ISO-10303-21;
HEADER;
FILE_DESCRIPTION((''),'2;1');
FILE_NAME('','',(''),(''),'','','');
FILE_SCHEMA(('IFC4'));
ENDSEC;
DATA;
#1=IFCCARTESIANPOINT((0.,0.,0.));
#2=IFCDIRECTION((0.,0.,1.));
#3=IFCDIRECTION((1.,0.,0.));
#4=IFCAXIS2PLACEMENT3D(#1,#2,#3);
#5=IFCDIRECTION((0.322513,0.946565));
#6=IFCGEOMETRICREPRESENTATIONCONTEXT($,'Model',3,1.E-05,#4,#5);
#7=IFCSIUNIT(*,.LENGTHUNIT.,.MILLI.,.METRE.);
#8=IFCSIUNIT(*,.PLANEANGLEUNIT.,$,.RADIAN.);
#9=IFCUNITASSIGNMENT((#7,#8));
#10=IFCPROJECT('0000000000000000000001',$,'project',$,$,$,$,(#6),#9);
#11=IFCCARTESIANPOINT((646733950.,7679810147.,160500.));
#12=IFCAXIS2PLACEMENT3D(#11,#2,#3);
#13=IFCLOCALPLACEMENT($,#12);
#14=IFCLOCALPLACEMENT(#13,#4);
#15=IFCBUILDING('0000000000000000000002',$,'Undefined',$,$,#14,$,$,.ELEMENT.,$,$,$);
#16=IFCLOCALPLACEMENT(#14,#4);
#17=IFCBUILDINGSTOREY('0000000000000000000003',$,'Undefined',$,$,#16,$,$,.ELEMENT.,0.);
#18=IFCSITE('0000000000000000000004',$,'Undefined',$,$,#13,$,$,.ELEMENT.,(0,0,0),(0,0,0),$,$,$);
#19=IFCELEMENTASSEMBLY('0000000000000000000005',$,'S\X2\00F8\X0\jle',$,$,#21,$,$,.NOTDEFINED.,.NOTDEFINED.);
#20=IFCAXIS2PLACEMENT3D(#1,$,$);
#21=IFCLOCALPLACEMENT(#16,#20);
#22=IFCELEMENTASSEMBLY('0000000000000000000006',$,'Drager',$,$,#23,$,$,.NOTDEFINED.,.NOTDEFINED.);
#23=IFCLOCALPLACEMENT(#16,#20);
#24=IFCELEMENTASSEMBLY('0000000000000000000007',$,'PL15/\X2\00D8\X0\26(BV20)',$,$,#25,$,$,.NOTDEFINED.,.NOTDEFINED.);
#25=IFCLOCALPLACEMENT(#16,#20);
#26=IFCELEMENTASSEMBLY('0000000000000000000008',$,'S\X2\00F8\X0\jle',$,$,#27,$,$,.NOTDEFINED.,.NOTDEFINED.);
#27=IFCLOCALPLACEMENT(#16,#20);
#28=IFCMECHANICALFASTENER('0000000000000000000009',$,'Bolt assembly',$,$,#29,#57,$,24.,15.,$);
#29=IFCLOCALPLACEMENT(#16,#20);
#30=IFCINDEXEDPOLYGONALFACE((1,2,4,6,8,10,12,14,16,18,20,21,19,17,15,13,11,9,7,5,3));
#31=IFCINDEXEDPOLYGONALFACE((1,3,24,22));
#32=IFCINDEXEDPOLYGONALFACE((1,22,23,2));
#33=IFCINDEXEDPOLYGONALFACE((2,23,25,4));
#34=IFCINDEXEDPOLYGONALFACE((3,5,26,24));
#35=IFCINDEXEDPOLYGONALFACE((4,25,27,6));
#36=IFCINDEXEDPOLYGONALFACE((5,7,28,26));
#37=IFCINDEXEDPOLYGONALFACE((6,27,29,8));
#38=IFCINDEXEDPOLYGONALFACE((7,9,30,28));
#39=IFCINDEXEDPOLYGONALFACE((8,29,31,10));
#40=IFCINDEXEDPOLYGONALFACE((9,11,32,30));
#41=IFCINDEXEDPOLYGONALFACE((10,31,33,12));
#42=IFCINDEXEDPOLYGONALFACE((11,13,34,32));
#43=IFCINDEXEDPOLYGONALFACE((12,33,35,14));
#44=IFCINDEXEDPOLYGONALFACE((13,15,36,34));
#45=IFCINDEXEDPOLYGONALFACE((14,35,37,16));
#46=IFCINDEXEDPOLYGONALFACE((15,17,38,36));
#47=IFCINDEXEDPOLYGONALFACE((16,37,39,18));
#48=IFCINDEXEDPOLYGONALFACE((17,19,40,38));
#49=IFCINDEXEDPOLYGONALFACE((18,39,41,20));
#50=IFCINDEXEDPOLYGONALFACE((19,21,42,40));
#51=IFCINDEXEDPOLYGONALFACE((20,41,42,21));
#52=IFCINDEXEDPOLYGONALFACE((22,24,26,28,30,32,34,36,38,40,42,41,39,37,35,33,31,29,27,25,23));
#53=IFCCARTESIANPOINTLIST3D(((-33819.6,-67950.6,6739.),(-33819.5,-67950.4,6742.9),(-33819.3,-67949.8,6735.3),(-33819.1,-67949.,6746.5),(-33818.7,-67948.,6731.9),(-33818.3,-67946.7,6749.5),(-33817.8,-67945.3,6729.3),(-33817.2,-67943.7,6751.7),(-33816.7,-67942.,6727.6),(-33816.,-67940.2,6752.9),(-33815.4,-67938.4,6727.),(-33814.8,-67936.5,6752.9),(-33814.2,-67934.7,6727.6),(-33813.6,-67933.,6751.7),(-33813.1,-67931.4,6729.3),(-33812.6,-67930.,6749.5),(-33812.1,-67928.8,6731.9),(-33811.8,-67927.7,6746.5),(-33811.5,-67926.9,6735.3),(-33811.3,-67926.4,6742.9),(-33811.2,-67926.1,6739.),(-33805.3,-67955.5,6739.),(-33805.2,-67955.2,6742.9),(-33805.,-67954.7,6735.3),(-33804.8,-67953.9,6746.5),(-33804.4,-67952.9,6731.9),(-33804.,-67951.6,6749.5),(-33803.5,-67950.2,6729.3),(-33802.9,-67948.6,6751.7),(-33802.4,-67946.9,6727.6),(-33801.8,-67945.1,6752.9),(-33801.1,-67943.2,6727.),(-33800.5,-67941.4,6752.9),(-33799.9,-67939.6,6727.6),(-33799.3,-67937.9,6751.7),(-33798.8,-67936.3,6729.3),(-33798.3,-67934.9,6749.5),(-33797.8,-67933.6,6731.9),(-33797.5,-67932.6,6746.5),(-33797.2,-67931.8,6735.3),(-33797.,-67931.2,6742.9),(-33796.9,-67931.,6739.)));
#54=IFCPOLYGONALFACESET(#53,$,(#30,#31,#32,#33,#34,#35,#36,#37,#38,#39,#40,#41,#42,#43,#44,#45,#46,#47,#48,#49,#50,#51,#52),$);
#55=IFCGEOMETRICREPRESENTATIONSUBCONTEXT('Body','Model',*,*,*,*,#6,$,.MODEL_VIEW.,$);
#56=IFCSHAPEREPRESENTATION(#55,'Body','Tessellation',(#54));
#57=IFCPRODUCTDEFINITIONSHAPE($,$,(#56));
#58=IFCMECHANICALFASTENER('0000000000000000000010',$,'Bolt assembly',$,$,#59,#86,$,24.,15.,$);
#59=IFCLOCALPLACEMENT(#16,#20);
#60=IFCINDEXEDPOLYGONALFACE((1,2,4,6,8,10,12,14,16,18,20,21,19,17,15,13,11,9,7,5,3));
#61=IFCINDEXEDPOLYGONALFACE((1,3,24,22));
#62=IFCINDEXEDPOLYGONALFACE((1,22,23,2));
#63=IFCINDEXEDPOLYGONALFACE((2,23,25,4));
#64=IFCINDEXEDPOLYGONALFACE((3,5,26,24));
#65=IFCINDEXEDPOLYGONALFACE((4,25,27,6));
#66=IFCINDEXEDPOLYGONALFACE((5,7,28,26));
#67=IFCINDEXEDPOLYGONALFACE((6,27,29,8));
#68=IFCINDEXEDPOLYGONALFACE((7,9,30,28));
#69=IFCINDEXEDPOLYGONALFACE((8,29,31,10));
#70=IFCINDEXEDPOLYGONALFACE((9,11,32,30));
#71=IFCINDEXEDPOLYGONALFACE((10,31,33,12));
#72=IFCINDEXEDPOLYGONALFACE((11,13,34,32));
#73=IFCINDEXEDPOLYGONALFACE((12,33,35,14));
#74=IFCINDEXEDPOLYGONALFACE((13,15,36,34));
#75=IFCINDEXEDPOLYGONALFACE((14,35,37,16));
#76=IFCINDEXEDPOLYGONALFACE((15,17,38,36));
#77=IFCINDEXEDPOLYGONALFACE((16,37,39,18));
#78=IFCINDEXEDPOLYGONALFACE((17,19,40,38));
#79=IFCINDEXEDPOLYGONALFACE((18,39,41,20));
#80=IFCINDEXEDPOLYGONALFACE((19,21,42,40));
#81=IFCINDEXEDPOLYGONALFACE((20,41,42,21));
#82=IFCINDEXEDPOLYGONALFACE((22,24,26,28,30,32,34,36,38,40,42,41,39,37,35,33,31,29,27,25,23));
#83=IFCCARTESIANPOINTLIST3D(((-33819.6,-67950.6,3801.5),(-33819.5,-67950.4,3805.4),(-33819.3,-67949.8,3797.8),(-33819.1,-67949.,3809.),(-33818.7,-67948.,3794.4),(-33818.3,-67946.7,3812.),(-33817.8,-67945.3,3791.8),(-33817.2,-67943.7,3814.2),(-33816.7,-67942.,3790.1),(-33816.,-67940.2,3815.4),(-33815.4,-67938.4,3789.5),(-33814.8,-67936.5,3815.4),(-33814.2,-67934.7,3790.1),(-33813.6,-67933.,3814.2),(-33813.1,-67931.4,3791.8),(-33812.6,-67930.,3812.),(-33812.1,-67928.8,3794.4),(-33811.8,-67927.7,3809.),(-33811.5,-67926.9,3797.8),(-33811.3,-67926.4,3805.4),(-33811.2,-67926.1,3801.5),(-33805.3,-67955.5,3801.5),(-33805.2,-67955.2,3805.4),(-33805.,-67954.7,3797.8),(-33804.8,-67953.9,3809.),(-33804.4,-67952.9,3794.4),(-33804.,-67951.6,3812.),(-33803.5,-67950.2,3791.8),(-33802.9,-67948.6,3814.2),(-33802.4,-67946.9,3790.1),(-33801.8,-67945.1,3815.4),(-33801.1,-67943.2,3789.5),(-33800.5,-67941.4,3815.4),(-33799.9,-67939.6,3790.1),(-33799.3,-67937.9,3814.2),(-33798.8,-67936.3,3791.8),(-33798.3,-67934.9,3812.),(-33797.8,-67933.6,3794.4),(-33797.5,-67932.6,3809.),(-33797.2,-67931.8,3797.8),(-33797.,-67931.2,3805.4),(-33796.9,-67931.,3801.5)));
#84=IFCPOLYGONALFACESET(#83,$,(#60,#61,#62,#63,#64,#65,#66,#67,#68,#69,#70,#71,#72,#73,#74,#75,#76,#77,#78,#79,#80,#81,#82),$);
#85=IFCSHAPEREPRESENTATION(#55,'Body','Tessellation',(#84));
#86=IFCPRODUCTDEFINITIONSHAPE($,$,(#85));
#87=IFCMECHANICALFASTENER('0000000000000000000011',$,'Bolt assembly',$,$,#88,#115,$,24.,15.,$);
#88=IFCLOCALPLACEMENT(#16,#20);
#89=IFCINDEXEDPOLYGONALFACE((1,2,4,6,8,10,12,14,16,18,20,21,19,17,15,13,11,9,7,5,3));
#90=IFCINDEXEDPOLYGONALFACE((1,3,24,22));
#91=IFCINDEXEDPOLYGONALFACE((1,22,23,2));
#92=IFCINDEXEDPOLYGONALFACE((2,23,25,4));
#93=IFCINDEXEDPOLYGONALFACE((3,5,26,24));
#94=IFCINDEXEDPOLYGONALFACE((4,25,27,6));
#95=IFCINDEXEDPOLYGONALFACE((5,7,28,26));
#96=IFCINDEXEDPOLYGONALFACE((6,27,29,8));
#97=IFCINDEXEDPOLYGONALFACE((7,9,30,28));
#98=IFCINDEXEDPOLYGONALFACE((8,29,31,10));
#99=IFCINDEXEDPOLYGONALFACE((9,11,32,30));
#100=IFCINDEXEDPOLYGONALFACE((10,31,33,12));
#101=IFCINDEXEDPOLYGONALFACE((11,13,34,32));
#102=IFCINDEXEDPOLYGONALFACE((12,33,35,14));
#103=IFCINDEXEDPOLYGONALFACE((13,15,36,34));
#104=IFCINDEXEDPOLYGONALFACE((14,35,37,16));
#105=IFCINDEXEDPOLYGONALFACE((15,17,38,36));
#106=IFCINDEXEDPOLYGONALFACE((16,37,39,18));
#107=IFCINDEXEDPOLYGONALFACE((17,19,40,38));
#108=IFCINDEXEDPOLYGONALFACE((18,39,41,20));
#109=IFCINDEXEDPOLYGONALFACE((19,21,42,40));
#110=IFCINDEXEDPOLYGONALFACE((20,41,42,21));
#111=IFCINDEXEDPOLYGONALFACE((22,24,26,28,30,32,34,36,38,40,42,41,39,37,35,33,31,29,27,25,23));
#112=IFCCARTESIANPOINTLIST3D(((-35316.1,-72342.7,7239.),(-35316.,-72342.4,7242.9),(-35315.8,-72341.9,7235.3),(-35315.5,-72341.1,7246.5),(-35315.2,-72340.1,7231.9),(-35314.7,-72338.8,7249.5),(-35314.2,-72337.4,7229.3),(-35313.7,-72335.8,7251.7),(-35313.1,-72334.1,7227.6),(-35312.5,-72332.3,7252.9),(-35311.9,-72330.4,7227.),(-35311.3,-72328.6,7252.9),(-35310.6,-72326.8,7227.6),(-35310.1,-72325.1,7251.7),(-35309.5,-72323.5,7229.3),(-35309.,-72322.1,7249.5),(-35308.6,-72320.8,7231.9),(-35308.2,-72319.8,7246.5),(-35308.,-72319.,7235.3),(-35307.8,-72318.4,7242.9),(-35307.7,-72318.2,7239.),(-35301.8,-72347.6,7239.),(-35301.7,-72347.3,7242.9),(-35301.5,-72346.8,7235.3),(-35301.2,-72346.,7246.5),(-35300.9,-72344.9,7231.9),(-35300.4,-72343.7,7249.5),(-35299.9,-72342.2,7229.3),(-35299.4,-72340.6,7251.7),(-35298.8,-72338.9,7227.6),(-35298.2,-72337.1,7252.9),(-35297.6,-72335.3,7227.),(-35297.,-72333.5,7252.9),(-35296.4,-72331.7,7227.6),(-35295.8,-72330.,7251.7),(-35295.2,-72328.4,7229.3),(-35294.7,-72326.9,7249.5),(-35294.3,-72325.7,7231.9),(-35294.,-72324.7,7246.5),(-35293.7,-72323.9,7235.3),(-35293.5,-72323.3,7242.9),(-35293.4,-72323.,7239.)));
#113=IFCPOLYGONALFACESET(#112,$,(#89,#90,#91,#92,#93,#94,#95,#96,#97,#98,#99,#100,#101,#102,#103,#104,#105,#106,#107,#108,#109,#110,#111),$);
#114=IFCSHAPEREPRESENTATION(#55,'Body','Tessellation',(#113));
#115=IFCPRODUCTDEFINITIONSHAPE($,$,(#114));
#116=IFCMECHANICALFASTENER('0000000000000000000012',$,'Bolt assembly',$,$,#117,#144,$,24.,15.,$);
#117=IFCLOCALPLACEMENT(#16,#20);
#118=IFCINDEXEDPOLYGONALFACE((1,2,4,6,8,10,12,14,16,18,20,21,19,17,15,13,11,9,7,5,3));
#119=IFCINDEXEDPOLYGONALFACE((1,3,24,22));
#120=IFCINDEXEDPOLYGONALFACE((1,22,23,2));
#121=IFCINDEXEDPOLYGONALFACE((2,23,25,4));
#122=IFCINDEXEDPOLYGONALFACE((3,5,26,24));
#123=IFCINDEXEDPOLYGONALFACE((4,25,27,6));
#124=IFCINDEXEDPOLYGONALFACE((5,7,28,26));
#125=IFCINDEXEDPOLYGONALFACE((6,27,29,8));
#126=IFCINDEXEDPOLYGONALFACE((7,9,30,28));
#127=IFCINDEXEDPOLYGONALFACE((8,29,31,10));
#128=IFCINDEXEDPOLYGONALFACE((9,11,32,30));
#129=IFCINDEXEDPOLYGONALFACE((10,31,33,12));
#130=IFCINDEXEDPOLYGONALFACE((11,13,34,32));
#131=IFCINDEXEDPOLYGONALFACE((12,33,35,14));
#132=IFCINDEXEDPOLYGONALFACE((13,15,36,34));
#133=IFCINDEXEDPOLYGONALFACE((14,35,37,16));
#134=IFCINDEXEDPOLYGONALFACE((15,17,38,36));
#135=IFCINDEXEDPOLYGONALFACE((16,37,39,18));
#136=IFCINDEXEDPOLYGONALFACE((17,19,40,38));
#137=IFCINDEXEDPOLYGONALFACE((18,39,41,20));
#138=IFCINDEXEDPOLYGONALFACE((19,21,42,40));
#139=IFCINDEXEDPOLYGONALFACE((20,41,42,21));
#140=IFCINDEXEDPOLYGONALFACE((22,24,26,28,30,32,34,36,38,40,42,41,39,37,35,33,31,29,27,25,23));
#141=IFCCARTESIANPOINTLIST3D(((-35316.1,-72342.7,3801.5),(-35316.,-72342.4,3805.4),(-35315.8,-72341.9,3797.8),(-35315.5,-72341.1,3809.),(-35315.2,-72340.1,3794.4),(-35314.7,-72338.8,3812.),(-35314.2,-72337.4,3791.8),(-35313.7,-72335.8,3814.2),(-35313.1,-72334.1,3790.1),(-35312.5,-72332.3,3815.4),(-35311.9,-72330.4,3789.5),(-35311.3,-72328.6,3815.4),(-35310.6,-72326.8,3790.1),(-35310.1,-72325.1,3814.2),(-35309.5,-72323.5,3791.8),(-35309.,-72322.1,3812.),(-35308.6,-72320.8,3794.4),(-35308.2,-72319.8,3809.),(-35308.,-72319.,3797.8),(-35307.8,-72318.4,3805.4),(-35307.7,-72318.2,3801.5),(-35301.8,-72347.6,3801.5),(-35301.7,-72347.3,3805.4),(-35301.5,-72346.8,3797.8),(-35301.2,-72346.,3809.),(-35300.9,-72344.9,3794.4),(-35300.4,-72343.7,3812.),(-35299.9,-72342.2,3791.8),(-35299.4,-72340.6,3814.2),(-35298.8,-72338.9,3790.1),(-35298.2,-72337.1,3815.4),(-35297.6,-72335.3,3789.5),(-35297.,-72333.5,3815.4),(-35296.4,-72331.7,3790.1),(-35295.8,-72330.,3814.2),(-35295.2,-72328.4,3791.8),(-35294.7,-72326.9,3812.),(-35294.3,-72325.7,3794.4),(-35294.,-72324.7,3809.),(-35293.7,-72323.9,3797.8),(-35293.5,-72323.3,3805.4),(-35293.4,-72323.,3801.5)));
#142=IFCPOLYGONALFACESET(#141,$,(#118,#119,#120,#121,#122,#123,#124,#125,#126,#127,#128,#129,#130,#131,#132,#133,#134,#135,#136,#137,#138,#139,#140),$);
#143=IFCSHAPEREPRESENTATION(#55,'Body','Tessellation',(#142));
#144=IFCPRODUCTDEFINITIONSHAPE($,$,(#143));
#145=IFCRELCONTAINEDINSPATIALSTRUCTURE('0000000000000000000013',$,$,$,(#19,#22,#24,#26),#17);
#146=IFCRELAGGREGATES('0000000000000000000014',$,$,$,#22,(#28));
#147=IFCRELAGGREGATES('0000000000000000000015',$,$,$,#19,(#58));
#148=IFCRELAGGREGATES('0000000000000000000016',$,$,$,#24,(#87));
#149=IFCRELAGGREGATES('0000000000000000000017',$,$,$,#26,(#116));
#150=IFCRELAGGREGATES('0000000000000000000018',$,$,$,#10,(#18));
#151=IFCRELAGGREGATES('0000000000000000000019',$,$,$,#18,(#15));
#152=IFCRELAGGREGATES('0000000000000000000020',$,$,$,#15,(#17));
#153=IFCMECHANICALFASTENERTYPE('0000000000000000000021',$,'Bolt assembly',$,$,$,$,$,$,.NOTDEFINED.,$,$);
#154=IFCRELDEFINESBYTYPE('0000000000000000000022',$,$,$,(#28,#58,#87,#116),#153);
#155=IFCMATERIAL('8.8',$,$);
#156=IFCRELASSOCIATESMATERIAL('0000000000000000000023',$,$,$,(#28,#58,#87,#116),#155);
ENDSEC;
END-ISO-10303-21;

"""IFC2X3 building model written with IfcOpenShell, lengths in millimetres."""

from ifc_helpers import new_model, si_unit, direction, frame, origin_with_axes, origin_2d_with_axis, place, context, subcontext, project, spatial, circle, extrude, source, transform, mapped, material, type_object, element, aggregate, save


model = new_model("IFC2X3")

# Units and contexts
model_context = context("Model", 3, precision=1e-05, world=origin_with_axes(), true_north=direction((0.322513, 0.946565)))
body_context = subcontext(model_context, "Body", "Model", "MODEL_VIEW")
ifc_project = project(units=[si_unit("LENGTHUNIT", "METRE", prefix="MILLI"), si_unit("PLANEANGLEUNIT", "RADIAN")], contexts=[model_context])

# Site, building, storey
site_placement = place(None, frame((646733950.0, 7679810147.0, 160500.0), z_axis=(0.0, 0.0, 1.0), x_axis=(1.0, 0.0, 0.0)))
site = spatial("IfcSite", under=ifc_project, at=site_placement, Name="Undefined", CompositionType="ELEMENT", RefLatitude=(0, 0, 0), RefLongitude=(0, 0, 0))
building_placement = place(site_placement, origin_with_axes())
building = spatial("IfcBuilding", under=site, at=building_placement, Name="Undefined", CompositionType="ELEMENT")
storey_placement = place(building_placement, origin_with_axes())
storey = spatial("IfcBuildingStorey", under=building, at=storey_placement, Name="Undefined", CompositionType="ELEMENT", Elevation=0.0)

# Element assembly
assembly_1_placement = place(storey_placement, origin_with_axes())
assembly_1 = element("IfcElementAssembly", 1, at=assembly_1_placement, inside=storey, Name="Søjle", AssemblyPlace="NOTDEFINED", PredefinedType="NOTDEFINED")

# Element assembly
assembly_2_placement = place(storey_placement, origin_with_axes())
assembly_2 = element("IfcElementAssembly", 2, at=assembly_2_placement, inside=storey, Name="Drager", AssemblyPlace="NOTDEFINED", PredefinedType="NOTDEFINED")

# Element assemblies
assembly_3_placement = place(storey_placement, origin_with_axes())
assembly_3 = element("IfcElementAssembly", 3, at=assembly_3_placement, inside=storey, Name="PL15/Ø26(BV20)", AssemblyPlace="NOTDEFINED", PredefinedType="NOTDEFINED")
assembly_4_placement = place(storey_placement, origin_with_axes())
assembly_4 = element("IfcElementAssembly", 4, at=assembly_4_placement, inside=storey, Name="Søjle", AssemblyPlace="NOTDEFINED", PredefinedType="NOTDEFINED")

# Mechanical fasteners
ifc_material_1 = material(Name="8.8")
mechanical_fastener_type = type_object("IfcMechanicalFastenerType", Name="Bolt assembly")
shared_shape_1 = source(origin_with_axes(), body_context, "Body", "SweptSolid", [
    extrude(circle(Radius=13.0, at=origin_2d_with_axis()), frame((0.0, -7.5, 0.0), z_axis=(0.0, 1.0, 0.0), x_axis=(1.0, 0.0, 0.0)), (0.0, 0.0, 1.0), 15.1),
])
mechanical_fastener_1_placement = place(assembly_2_placement, frame((-33808.3, -67940.8, 6740.0), z_axis=(-0.322513, -0.946565, 0.0), x_axis=(0.0, 0.0, -1.0)))
mechanical_fastener_1 = element("IfcMechanicalFastener", 5, at=mechanical_fastener_1_placement, type_object=mechanical_fastener_type, material=ifc_material_1, Name="Bolt assembly", NominalDiameter=24.0, NominalLength=15.0, context=body_context, shape_type="MappedRepresentation", body=[
    mapped(shared_shape_1, transform((0.0, 0.0, 0.0))),
])
aggregate(assembly_2, [mechanical_fastener_1])
mechanical_fastener_2_placement = place(assembly_1_placement, frame((-33808.3, -67940.8, 3802.5), z_axis=(-0.322513, -0.946565, 0.0), x_axis=(0.0, 0.0, -1.0)))
mechanical_fastener_2 = element("IfcMechanicalFastener", 6, at=mechanical_fastener_2_placement, type_object=mechanical_fastener_type, material=ifc_material_1, Name="Bolt assembly", NominalDiameter=24.0, NominalLength=15.0, context=body_context, shape_type="MappedRepresentation", body=[
    mapped(shared_shape_1, transform((0.0, 0.0, 0.0))),
])
aggregate(assembly_1, [mechanical_fastener_2])
mechanical_fastener_3_placement = place(assembly_3_placement, frame((-35304.8, -72332.9, 7240.0), z_axis=(-0.322513, -0.946565, 0.0), x_axis=(0.0, 0.0, -1.0)))
mechanical_fastener_3 = element("IfcMechanicalFastener", 7, at=mechanical_fastener_3_placement, type_object=mechanical_fastener_type, material=ifc_material_1, Name="Bolt assembly", NominalDiameter=24.0, NominalLength=15.0, context=body_context, shape_type="MappedRepresentation", body=[
    mapped(shared_shape_1, transform((0.0, 0.0, 0.0))),
])
aggregate(assembly_3, [mechanical_fastener_3])
mechanical_fastener_4_placement = place(assembly_4_placement, frame((-35304.8, -72332.9, 3802.5), z_axis=(-0.322513, -0.946565, 0.0), x_axis=(0.0, 0.0, -1.0)))
mechanical_fastener_4 = element("IfcMechanicalFastener", 8, at=mechanical_fastener_4_placement, type_object=mechanical_fastener_type, material=ifc_material_1, Name="Bolt assembly", NominalDiameter=24.0, NominalLength=15.0, context=body_context, shape_type="MappedRepresentation", body=[
    mapped(shared_shape_1, transform((0.0, 0.0, 0.0))),
])
aggregate(assembly_4, [mechanical_fastener_4])

save(model, "model.ifc")
